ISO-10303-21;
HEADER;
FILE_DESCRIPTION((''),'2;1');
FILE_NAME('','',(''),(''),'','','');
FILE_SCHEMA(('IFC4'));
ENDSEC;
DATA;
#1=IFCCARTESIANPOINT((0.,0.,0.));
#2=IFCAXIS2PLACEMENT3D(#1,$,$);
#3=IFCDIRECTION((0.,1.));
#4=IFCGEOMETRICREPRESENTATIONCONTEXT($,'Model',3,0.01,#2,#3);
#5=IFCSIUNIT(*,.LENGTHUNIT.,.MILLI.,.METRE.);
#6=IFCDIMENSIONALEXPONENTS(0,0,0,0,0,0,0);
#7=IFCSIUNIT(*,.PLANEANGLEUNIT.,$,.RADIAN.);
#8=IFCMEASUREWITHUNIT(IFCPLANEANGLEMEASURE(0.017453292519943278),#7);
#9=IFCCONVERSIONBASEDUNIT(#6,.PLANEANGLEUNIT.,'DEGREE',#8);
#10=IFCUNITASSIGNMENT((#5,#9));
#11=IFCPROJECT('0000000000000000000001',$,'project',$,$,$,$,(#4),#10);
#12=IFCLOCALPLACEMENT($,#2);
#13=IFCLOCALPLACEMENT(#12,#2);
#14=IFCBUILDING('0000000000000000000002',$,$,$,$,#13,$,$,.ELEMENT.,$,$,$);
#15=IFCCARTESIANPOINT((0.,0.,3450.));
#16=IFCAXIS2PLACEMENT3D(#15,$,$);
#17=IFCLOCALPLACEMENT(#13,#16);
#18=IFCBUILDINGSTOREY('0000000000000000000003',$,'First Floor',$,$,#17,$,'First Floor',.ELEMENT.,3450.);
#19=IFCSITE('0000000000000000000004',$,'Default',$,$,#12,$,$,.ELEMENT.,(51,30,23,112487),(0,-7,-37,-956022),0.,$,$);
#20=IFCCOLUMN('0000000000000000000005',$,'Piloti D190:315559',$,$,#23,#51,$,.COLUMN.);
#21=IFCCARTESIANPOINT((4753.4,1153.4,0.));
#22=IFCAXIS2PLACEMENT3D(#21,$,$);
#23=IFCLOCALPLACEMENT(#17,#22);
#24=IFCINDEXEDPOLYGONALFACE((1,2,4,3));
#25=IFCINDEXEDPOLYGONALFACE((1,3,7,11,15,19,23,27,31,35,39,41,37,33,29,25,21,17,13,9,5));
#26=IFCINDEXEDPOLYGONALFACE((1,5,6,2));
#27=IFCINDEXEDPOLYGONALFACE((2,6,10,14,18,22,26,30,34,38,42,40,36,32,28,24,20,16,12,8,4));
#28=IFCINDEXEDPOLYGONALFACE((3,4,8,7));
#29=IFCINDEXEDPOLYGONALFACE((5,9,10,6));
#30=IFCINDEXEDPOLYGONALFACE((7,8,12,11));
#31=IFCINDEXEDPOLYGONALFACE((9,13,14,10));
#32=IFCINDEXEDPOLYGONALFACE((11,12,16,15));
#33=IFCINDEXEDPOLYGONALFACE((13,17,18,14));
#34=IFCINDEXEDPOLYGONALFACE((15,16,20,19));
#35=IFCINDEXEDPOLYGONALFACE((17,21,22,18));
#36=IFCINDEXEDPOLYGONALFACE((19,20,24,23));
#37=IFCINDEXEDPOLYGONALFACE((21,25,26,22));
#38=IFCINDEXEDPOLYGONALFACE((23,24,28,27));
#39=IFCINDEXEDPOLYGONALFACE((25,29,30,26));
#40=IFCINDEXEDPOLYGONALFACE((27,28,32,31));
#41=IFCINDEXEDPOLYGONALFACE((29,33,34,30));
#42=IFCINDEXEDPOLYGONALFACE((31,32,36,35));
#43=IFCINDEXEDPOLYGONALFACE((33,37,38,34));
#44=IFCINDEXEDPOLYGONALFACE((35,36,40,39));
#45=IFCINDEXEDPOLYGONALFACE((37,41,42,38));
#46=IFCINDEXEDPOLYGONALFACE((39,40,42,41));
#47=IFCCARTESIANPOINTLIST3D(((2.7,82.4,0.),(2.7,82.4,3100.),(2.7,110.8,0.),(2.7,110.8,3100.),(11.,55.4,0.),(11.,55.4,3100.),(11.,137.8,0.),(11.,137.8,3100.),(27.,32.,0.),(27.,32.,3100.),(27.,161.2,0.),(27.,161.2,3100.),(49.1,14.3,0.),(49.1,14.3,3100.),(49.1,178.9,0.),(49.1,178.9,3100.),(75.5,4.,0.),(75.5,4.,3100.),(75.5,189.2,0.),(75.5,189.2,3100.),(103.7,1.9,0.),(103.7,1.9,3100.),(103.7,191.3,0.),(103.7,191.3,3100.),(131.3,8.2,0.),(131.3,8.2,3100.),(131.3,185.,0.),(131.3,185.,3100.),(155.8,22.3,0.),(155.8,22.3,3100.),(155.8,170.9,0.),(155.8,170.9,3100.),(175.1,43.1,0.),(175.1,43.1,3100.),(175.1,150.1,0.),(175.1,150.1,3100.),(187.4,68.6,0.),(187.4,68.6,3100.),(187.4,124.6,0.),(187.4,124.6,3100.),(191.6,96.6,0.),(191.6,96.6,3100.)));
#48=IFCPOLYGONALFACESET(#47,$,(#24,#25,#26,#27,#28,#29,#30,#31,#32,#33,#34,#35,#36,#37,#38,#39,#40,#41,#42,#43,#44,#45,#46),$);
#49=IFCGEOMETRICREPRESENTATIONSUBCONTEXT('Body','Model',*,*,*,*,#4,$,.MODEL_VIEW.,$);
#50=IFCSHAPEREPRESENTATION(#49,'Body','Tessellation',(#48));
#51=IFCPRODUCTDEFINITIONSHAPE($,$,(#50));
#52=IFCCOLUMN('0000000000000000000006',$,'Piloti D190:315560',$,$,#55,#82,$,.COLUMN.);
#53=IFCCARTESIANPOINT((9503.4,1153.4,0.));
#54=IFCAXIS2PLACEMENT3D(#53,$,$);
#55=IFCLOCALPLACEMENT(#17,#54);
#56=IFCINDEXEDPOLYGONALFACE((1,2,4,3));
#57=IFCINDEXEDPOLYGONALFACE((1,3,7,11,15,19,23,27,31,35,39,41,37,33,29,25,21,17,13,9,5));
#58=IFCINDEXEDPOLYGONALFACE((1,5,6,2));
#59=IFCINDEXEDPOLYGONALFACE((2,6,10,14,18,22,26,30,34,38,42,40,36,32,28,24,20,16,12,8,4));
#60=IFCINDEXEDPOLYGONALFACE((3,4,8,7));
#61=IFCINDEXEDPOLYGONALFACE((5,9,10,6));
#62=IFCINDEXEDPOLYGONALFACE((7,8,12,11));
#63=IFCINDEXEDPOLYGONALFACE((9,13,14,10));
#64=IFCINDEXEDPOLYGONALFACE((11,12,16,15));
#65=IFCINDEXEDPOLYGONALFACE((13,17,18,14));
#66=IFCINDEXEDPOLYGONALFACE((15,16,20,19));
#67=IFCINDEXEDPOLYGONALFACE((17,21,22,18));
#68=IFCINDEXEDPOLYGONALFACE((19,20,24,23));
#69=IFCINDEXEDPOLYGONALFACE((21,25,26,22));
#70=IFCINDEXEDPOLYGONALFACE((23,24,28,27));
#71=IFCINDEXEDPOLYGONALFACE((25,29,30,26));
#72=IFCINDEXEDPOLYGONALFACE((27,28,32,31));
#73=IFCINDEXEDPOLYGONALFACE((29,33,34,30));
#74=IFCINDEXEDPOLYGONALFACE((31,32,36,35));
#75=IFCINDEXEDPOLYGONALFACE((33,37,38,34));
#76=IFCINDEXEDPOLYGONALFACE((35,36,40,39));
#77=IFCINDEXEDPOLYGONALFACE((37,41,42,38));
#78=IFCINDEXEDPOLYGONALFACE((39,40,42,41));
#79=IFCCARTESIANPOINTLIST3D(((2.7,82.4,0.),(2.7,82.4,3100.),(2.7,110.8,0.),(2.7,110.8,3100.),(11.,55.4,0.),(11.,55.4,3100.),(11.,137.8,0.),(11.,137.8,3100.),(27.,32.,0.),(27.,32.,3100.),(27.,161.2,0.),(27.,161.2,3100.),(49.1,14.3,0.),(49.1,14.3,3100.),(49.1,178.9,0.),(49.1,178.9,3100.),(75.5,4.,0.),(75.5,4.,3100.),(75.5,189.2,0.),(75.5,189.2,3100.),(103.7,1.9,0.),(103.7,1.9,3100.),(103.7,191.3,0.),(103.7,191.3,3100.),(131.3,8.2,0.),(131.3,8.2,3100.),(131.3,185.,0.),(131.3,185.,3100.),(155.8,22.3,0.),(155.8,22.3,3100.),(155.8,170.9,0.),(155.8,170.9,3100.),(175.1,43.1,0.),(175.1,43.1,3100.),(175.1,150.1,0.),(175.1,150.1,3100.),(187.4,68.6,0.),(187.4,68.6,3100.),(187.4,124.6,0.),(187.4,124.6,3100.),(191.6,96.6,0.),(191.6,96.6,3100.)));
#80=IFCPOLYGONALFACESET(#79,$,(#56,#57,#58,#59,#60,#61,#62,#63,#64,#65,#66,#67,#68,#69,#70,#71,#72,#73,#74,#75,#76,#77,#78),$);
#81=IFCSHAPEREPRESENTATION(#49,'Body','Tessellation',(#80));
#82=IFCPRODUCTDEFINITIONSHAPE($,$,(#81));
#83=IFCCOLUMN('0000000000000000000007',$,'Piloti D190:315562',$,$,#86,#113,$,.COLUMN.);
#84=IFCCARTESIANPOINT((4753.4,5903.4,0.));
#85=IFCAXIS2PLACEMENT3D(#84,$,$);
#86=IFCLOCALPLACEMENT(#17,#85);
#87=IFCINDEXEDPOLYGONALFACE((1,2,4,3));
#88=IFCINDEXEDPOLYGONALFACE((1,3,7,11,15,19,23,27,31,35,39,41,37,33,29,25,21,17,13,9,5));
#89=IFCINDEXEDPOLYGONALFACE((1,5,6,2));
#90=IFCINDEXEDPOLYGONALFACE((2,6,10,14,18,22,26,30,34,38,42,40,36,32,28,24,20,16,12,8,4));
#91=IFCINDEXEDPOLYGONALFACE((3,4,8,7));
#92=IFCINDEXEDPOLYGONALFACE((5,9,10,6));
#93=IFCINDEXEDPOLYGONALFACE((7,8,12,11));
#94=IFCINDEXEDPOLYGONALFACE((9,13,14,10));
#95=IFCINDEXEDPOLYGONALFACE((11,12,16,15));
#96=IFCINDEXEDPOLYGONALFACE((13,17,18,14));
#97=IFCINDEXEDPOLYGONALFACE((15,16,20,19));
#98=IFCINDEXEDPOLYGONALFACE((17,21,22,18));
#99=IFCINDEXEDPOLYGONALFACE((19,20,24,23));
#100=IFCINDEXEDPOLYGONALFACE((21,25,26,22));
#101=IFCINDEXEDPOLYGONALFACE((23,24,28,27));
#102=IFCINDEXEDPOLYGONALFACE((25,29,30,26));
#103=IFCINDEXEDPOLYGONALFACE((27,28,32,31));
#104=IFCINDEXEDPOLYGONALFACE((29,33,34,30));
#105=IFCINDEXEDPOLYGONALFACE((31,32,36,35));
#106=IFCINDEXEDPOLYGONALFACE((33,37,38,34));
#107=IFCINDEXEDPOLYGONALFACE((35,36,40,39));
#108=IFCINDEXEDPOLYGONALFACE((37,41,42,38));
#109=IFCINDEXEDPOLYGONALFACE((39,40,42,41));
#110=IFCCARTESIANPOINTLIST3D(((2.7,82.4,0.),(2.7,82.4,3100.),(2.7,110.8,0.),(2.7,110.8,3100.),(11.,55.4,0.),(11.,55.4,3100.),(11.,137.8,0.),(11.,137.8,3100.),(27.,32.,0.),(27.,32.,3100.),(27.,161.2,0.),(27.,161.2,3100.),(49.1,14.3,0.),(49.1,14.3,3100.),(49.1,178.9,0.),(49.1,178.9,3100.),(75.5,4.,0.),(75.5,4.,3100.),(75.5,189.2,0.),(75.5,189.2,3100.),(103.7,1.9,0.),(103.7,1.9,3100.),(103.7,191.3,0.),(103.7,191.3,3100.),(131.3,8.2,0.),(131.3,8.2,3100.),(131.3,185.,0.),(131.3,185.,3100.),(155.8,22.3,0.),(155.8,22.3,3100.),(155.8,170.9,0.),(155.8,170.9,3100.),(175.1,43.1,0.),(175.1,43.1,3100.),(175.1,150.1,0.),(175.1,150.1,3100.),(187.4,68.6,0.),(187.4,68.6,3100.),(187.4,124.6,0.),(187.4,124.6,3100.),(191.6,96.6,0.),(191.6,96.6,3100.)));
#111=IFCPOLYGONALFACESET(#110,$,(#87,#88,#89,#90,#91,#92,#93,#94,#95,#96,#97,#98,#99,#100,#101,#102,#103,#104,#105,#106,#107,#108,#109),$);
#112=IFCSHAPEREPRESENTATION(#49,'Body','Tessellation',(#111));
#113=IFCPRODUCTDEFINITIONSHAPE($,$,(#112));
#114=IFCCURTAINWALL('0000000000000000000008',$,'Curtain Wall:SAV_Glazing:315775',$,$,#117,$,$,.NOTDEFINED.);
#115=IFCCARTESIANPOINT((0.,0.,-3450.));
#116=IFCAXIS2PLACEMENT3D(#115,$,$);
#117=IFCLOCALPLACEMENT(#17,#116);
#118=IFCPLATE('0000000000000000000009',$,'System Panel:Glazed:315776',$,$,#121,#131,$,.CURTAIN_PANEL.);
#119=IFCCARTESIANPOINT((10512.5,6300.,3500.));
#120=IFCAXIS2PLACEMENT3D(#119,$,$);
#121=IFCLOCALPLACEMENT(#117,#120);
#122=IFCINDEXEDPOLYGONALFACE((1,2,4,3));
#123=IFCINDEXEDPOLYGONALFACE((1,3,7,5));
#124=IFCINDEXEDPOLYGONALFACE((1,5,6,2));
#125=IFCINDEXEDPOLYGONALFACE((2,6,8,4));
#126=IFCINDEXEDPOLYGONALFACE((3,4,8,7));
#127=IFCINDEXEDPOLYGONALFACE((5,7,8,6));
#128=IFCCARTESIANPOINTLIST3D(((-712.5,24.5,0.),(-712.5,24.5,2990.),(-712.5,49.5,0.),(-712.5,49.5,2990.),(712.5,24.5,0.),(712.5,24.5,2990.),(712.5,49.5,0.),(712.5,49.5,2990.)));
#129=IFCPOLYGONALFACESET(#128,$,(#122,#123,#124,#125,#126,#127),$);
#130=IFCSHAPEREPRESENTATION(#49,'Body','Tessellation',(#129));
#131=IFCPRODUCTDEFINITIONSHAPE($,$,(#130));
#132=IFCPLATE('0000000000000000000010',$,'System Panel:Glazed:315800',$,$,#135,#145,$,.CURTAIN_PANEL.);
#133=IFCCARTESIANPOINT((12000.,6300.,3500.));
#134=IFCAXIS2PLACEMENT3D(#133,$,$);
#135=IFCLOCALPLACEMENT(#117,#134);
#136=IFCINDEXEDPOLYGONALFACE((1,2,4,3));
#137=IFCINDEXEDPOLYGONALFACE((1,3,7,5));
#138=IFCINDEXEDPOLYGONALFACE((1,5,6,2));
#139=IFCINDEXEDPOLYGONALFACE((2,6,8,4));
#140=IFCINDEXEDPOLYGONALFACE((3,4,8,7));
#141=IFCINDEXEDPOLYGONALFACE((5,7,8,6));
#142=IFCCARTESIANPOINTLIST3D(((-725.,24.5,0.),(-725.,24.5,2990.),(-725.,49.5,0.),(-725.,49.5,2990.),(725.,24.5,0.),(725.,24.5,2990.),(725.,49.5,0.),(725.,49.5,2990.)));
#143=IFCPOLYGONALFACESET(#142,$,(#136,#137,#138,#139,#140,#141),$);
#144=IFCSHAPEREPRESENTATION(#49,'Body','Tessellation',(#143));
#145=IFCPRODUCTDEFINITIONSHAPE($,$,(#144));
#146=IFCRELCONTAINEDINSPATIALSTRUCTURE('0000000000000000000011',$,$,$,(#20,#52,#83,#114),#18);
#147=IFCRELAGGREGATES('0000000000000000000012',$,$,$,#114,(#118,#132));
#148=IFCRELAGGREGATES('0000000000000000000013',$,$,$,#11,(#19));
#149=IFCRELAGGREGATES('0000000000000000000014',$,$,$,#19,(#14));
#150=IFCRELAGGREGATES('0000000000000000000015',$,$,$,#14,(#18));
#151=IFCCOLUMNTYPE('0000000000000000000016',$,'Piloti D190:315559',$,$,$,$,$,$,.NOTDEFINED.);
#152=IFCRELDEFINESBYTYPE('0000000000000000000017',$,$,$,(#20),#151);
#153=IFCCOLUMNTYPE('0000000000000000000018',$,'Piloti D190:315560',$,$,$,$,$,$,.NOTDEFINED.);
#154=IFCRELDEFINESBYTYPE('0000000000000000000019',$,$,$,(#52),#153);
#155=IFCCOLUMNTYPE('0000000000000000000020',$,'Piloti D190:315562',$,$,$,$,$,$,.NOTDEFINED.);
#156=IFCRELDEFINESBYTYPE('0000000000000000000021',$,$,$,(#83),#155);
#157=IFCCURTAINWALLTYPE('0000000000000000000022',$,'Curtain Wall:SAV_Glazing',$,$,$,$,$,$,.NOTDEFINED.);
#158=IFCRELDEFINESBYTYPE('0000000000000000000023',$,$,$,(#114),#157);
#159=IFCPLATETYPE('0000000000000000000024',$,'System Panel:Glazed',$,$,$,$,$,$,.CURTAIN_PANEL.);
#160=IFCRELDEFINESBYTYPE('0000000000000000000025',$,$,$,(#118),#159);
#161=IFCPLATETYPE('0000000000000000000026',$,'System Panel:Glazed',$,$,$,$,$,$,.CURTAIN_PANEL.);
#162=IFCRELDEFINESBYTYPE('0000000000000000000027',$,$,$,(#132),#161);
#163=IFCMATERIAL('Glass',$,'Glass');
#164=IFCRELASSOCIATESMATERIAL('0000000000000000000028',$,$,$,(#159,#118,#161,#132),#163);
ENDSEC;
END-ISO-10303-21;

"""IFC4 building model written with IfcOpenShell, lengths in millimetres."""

from ifc_helpers import new_model, entity, si_unit, converted_unit, direction, frame, origin, origin_2d_with_axis, place, context, subcontext, project, spatial, rectangle, circle, extrude, source, transform, mapped, material, type_object, type_shapes, element, aggregate, save


model = new_model("IFC4")

# Units and contexts
model_context = context("Model", 3, precision=0.01, world=origin(), true_north=direction((0.0, 1.0)))
body_context = subcontext(model_context, "Body", "Model", "MODEL_VIEW")
ifc_project = project(units=[si_unit("LENGTHUNIT", "METRE", prefix="MILLI"), converted_unit("PLANEANGLEUNIT", "DEGREE", entity("IfcPlaneAngleMeasure", 0.017453292519943278), si_unit("PLANEANGLEUNIT", "RADIAN"), dimensions=[0, 0, 0, 0, 0, 0, 0])], contexts=[model_context])

# Site, building, storey
site_placement = place(None, origin())
site = spatial("IfcSite", under=ifc_project, at=site_placement, Name="Default", CompositionType="ELEMENT", RefLatitude=(51, 30, 23, 112487), RefLongitude=(0, -7, -37, -956022), RefElevation=0.0)
building_placement = place(site_placement, origin())
building = spatial("IfcBuilding", under=site, at=building_placement, CompositionType="ELEMENT")
storey_placement = place(building_placement, frame((0.0, 0.0, 3450.0)))
storey = spatial("IfcBuildingStorey", under=building, at=storey_placement, Name="First Floor", LongName="First Floor", CompositionType="ELEMENT", Elevation=3450.0)

# Columns
column_type_1 = type_object("IfcColumnType", Name="Piloti D190:315559", PredefinedType="NOTDEFINED")
column_1_placement = place(storey_placement, frame((4753.4, 1153.4, 0.0)))
element("IfcColumn", 1, at=column_1_placement, inside=storey, type_object=column_type_1, Name="Piloti D190:315559", PredefinedType="COLUMN", context=body_context, shape_type="SweptSolid", body=[
    extrude(circle(Radius=95.0, at=origin_2d_with_axis()), frame((96.6, 96.6, 0.0)), (0.0, 0.0, 1.0), 3100.0),
])
column_type_2 = type_object("IfcColumnType", Name="Piloti D190:315560", PredefinedType="NOTDEFINED")
column_2_placement = place(storey_placement, frame((9503.4, 1153.4, 0.0)))
element("IfcColumn", 2, at=column_2_placement, inside=storey, type_object=column_type_2, Name="Piloti D190:315560", PredefinedType="COLUMN", context=body_context, shape_type="SweptSolid", body=[
    extrude(circle(Radius=95.0, at=origin_2d_with_axis()), frame((96.6, 96.6, 0.0)), (0.0, 0.0, 1.0), 3100.0),
])
column_type_3 = type_object("IfcColumnType", Name="Piloti D190:315562", PredefinedType="NOTDEFINED")
column_3_placement = place(storey_placement, frame((4753.4, 5903.4, 0.0)))
element("IfcColumn", 3, at=column_3_placement, inside=storey, type_object=column_type_3, Name="Piloti D190:315562", PredefinedType="COLUMN", context=body_context, shape_type="SweptSolid", body=[
    extrude(circle(Radius=95.0, at=origin_2d_with_axis()), frame((96.6, 96.6, 0.0)), (0.0, 0.0, 1.0), 3100.0),
])

# Curtain wall
curtain_wall_type = type_object("IfcCurtainWallType", Name="Curtain Wall:SAV_Glazing", PredefinedType="NOTDEFINED")
curtain_wall_1_placement = place(storey_placement, frame((0.0, 0.0, -3450.0)))
curtain_wall_1 = element("IfcCurtainWall", 4, at=curtain_wall_1_placement, inside=storey, type_object=curtain_wall_type, Name="Curtain Wall:SAV_Glazing:315775", PredefinedType="NOTDEFINED")

# Plates
ifc_material_1 = material(Name="Glass", Category="Glass")
plate_type_1 = type_object("IfcPlateType", Name="System Panel:Glazed", PredefinedType="CURTAIN_PANEL", material=ifc_material_1)
shared_shape_1 = source(origin(), body_context, "Body", "SweptSolid", [
    extrude(rectangle(XDim=25.0, YDim=1425.0, at=origin_2d_with_axis()), frame((0.0, 37.0, 0.0), z_axis=(0.0, 0.0, 1.0), x_axis=(0.0, 1.0, 0.0)), (0.0, 0.0, 1.0), 2990.0),
])
type_shapes(plate_type_1, [shared_shape_1])
plate_1_placement = place(curtain_wall_1_placement, frame((10512.5, 6300.0, 3500.0)))
plate_1 = element("IfcPlate", 5, at=plate_1_placement, type_object=plate_type_1, material=ifc_material_1, Name="System Panel:Glazed:315776", PredefinedType="CURTAIN_PANEL", context=body_context, shape_type="MappedRepresentation", body=[
    mapped(shared_shape_1, transform((0.0, 0.0, 0.0), scale=1.0)),
])
plate_type_2 = type_object("IfcPlateType", Name="System Panel:Glazed", PredefinedType="CURTAIN_PANEL", material=ifc_material_1)
shared_shape_2 = source(origin(), body_context, "Body", "SweptSolid", [
    extrude(rectangle(XDim=25.0, YDim=1450.0, at=origin_2d_with_axis()), frame((0.0, 37.0, 0.0), z_axis=(0.0, 0.0, 1.0), x_axis=(0.0, 1.0, 0.0)), (0.0, 0.0, 1.0), 2990.0),
])
type_shapes(plate_type_2, [shared_shape_2])
plate_2_placement = place(curtain_wall_1_placement, frame((12000.0, 6300.0, 3500.0)))
plate_2 = element("IfcPlate", 6, at=plate_2_placement, type_object=plate_type_2, material=ifc_material_1, Name="System Panel:Glazed:315800", PredefinedType="CURTAIN_PANEL", context=body_context, shape_type="MappedRepresentation", body=[
    mapped(shared_shape_2, transform((0.0, 0.0, 0.0), scale=1.0)),
])
aggregate(curtain_wall_1, [plate_1, plate_2])

save(model, "model.ifc")
